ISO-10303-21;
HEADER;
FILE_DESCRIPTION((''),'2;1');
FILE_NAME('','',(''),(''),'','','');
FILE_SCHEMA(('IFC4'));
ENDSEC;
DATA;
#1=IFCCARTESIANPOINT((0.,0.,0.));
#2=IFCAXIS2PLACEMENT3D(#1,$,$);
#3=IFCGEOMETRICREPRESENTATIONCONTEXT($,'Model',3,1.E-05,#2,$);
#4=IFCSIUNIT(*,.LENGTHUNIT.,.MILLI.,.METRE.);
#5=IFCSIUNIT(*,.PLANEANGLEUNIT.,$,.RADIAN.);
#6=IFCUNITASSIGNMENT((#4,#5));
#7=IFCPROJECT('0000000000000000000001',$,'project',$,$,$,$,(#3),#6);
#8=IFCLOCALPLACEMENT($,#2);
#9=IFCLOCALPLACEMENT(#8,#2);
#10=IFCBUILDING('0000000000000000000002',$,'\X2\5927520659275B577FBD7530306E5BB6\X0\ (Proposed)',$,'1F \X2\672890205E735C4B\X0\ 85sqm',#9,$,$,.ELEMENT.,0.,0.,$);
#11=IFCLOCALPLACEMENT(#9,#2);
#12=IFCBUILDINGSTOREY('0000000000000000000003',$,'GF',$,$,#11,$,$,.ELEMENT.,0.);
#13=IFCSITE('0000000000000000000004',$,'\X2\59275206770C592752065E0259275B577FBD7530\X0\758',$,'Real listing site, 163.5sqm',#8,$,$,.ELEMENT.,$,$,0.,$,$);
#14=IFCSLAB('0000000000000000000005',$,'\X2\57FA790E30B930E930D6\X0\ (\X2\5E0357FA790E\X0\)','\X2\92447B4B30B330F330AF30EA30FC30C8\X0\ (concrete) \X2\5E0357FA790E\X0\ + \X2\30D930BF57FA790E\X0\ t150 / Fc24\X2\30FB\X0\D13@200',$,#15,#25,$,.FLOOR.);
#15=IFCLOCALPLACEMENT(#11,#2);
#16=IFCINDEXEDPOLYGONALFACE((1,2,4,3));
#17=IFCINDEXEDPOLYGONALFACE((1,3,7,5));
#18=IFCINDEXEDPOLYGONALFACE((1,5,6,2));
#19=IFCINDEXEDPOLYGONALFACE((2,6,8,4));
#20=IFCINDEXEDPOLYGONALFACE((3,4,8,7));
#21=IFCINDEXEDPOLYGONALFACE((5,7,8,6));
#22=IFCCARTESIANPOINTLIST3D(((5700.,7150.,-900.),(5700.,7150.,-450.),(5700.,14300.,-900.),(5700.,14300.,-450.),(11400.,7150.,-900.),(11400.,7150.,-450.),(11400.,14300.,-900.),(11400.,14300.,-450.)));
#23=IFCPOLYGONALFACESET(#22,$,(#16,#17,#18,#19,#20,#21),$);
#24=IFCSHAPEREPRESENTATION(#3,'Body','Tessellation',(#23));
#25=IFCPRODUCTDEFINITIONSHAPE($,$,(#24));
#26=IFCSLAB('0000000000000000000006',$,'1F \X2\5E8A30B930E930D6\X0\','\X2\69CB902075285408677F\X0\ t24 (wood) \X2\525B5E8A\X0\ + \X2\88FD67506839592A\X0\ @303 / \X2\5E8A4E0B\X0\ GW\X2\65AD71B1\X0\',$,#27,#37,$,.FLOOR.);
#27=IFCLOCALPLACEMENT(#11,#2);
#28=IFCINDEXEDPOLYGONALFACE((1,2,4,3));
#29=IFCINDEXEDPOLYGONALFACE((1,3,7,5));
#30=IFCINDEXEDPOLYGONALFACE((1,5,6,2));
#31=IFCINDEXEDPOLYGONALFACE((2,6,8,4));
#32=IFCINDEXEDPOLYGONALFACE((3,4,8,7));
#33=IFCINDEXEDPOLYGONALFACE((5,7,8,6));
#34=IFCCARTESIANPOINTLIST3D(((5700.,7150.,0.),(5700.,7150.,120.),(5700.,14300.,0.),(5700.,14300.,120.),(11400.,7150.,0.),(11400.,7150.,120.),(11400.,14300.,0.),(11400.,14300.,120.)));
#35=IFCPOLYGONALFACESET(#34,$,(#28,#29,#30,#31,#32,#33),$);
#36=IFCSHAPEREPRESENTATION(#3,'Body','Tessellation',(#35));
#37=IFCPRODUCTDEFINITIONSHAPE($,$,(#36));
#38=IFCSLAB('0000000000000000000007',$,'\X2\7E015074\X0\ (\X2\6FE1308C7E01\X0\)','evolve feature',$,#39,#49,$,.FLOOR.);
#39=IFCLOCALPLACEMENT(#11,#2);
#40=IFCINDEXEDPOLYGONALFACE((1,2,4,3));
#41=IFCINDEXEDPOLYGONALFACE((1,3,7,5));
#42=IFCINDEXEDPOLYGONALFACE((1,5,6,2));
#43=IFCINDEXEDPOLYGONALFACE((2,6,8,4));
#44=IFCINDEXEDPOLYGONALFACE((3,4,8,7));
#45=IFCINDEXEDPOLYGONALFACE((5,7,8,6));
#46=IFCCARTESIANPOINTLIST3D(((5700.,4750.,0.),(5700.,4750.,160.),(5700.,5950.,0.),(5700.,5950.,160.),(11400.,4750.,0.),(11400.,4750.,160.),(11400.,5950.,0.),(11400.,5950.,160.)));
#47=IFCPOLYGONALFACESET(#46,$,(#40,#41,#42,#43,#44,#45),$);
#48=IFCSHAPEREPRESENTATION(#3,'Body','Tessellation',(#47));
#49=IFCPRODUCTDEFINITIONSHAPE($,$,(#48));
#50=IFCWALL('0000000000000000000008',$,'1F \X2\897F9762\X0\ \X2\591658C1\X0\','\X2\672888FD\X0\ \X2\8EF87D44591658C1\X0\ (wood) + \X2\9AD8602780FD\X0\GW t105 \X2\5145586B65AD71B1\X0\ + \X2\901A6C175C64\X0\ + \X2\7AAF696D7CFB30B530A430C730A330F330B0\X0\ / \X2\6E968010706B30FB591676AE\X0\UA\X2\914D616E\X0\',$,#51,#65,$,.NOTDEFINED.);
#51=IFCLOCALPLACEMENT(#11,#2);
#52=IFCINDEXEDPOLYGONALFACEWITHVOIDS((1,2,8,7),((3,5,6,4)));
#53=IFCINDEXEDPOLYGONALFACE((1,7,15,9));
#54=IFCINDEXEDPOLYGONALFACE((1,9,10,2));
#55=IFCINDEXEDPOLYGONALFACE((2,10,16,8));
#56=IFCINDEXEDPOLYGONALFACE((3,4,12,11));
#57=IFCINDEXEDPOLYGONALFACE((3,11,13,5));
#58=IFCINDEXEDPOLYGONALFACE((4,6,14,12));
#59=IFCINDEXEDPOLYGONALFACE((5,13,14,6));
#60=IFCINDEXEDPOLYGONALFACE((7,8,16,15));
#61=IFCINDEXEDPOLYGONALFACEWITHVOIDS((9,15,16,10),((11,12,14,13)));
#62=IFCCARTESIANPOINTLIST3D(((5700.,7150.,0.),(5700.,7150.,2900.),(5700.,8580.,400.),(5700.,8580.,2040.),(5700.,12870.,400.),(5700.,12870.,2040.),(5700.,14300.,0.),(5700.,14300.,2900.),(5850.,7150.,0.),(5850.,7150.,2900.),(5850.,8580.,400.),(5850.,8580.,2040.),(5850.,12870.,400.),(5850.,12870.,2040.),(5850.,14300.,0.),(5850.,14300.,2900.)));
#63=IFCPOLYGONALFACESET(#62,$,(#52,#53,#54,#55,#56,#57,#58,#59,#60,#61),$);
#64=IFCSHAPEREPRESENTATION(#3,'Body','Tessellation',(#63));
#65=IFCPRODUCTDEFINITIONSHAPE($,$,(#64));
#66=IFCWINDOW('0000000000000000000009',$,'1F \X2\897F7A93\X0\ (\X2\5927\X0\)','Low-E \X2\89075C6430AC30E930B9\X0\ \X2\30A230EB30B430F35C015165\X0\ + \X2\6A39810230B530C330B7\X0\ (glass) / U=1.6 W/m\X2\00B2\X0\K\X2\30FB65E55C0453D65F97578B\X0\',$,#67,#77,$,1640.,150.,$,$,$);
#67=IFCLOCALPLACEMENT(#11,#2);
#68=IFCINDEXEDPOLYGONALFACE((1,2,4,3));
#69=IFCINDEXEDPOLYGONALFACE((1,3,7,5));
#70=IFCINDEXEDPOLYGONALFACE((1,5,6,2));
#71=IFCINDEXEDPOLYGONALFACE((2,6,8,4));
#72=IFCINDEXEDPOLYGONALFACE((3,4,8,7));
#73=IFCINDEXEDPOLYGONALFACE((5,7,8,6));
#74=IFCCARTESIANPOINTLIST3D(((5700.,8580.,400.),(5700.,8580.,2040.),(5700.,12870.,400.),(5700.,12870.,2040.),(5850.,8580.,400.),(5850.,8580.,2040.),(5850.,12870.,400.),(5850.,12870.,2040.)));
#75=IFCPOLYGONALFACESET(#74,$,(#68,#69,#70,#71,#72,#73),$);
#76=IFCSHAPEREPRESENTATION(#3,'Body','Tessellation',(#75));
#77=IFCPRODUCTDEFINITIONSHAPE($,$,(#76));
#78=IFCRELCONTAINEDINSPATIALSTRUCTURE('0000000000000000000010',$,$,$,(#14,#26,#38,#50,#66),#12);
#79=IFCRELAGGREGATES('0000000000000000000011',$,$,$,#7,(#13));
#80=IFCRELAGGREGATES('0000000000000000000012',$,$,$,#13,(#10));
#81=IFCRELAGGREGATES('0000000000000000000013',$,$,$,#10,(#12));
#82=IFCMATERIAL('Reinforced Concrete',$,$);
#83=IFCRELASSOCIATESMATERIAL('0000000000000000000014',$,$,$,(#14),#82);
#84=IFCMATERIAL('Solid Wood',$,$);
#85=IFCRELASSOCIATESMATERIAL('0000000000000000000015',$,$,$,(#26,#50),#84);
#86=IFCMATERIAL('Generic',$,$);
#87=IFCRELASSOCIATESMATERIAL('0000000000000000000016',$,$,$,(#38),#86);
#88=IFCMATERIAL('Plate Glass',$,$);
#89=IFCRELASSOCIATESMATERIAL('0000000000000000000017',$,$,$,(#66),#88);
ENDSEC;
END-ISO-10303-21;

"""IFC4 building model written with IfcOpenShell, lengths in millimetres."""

from ifc_helpers import new_model, si_unit, frame, frame_2d, origin, place, context, project, spatial, rectangle, extrude, material, element, fill, save


model = new_model("IFC4")

# Units and contexts
model_context = context("Model", 3, precision=1e-05, world=origin())
ifc_project = project(units=[si_unit("LENGTHUNIT", "METRE", prefix="MILLI"), si_unit("PLANEANGLEUNIT", "RADIAN")], contexts=[model_context])

# Site, building, storey
site_placement = place(None, origin())
site = spatial("IfcSite", under=ifc_project, at=site_placement, Name="大分県大分市大字羽田758", ObjectType="Real listing site, 163.5sqm", CompositionType="ELEMENT", RefElevation=0.0)
building_placement = place(site_placement, origin())
building = spatial("IfcBuilding", under=site, at=building_placement, Name="大分大字羽田の家 (Proposed)", ObjectType="1F 木造平屋 85sqm", CompositionType="ELEMENT", ElevationOfRefHeight=0.0, ElevationOfTerrain=0.0)
storey_placement = place(building_placement, origin())
storey = spatial("IfcBuildingStorey", under=building, at=storey_placement, Name="GF", CompositionType="ELEMENT", Elevation=0.0)

# Slabs
ifc_material_1 = material(Name="Reinforced Concrete")
slab_1_placement = place(storey_placement, frame((2850.0, 3575.0, -450.0)))
element("IfcSlab", 1, at=slab_1_placement, inside=storey, material=ifc_material_1, Name="基礎スラブ (布基礎)", Description="鉄筋コンクリート (concrete) 布基礎 + ベタ基礎 t150 / Fc24・D13@200", PredefinedType="FLOOR", context=model_context, shape_type="SweptSolid", body=[
    extrude(rectangle(XDim=5700.0, YDim=7150.0, at=frame_2d((2850.0, 3575.0))), frame((2850.0, 3575.0, -450.0)), (0.0, 0.0, 1.0), 450.0),
])
ifc_material_2 = material(Name="Solid Wood")
slab_2_placement = place(storey_placement, frame((2850.0, 3575.0, 0.0)))
element("IfcSlab", 2, at=slab_2_placement, inside=storey, material=ifc_material_2, Name="1F 床スラブ", Description="構造用合板 t24 (wood) 剛床 + 製材根太 @303 / 床下 GW断熱", PredefinedType="FLOOR", context=model_context, shape_type="SweptSolid", body=[
    extrude(rectangle(XDim=5700.0, YDim=7150.0, at=frame_2d((2850.0, 3575.0))), frame((2850.0, 3575.0, 0.0)), (0.0, 0.0, 1.0), 120.0),
])
ifc_material_3 = material(Name="Generic")
slab_3_placement = place(storey_placement, frame((2850.0, 2375.0, 0.0)))
element("IfcSlab", 3, at=slab_3_placement, inside=storey, material=ifc_material_3, Name="縁側 (濡れ縁)", Description="evolve feature", PredefinedType="FLOOR", context=model_context, shape_type="SweptSolid", body=[
    extrude(rectangle(XDim=5700.0, YDim=1200.0, at=frame_2d((2850.0, 600.0))), frame((2850.0, 2375.0, 0.0)), (0.0, 0.0, 1.0), 160.0),
])

# Shared definitions
ifc_material_4 = material(Name="Plate Glass")

# Wall, opening, window
wall_1_placement = place(storey_placement, frame((2850.0, 3575.0, 0.0)))
wall_1 = element("IfcWall", 4, at=wall_1_placement, inside=storey, material=ifc_material_2, Name="1F 西面 外壁", Description="木製 軸組外壁 (wood) + 高性能GW t105 充填断熱 + 通気層 + 窯業系サイディング / 準耐火・外皮UA配慮", PredefinedType="NOTDEFINED", context=model_context, shape_type="SweptSolid", body=[
    extrude(rectangle(XDim=150.0, YDim=7150.0, at=frame_2d((75.0, 3575.0))), frame((2850.0, 3575.0, 0.0)), (0.0, 0.0, 1.0), 2900.0),
])
opening_1_placement = place(storey_placement, frame((2850.0, 4290.0, 200.0)))
opening_1 = element("IfcOpeningElement", 5, at=opening_1_placement, cuts=wall_1, PredefinedType="NOTDEFINED", context=model_context, shape_type="SweptSolid", body=[
    extrude(rectangle(XDim=150.0, YDim=4290.0, at=frame_2d((75.0, 2145.0))), frame((2850.0, 4290.0, 200.0)), (0.0, 0.0, 1.0), 1640.0),
])
window_1_placement = place(storey_placement, frame((2850.0, 4290.0, 200.0)))
window_1 = element("IfcWindow", 6, at=window_1_placement, inside=storey, material=ifc_material_4, Name="1F 西窓 (大)", Description="Low-E 複層ガラス アルゴン封入 + 樹脂サッシ (glass) / U=1.6 W/m²K・日射取得型", OverallHeight=1640.0, OverallWidth=150.0, context=model_context, shape_type="SweptSolid", body=[
    extrude(rectangle(XDim=150.0, YDim=4290.0, at=frame_2d((75.0, 2145.0))), frame((2850.0, 4290.0, 200.0)), (0.0, 0.0, 1.0), 1640.0),
])
fill(opening_1, window_1)

save(model, "model.ifc")
